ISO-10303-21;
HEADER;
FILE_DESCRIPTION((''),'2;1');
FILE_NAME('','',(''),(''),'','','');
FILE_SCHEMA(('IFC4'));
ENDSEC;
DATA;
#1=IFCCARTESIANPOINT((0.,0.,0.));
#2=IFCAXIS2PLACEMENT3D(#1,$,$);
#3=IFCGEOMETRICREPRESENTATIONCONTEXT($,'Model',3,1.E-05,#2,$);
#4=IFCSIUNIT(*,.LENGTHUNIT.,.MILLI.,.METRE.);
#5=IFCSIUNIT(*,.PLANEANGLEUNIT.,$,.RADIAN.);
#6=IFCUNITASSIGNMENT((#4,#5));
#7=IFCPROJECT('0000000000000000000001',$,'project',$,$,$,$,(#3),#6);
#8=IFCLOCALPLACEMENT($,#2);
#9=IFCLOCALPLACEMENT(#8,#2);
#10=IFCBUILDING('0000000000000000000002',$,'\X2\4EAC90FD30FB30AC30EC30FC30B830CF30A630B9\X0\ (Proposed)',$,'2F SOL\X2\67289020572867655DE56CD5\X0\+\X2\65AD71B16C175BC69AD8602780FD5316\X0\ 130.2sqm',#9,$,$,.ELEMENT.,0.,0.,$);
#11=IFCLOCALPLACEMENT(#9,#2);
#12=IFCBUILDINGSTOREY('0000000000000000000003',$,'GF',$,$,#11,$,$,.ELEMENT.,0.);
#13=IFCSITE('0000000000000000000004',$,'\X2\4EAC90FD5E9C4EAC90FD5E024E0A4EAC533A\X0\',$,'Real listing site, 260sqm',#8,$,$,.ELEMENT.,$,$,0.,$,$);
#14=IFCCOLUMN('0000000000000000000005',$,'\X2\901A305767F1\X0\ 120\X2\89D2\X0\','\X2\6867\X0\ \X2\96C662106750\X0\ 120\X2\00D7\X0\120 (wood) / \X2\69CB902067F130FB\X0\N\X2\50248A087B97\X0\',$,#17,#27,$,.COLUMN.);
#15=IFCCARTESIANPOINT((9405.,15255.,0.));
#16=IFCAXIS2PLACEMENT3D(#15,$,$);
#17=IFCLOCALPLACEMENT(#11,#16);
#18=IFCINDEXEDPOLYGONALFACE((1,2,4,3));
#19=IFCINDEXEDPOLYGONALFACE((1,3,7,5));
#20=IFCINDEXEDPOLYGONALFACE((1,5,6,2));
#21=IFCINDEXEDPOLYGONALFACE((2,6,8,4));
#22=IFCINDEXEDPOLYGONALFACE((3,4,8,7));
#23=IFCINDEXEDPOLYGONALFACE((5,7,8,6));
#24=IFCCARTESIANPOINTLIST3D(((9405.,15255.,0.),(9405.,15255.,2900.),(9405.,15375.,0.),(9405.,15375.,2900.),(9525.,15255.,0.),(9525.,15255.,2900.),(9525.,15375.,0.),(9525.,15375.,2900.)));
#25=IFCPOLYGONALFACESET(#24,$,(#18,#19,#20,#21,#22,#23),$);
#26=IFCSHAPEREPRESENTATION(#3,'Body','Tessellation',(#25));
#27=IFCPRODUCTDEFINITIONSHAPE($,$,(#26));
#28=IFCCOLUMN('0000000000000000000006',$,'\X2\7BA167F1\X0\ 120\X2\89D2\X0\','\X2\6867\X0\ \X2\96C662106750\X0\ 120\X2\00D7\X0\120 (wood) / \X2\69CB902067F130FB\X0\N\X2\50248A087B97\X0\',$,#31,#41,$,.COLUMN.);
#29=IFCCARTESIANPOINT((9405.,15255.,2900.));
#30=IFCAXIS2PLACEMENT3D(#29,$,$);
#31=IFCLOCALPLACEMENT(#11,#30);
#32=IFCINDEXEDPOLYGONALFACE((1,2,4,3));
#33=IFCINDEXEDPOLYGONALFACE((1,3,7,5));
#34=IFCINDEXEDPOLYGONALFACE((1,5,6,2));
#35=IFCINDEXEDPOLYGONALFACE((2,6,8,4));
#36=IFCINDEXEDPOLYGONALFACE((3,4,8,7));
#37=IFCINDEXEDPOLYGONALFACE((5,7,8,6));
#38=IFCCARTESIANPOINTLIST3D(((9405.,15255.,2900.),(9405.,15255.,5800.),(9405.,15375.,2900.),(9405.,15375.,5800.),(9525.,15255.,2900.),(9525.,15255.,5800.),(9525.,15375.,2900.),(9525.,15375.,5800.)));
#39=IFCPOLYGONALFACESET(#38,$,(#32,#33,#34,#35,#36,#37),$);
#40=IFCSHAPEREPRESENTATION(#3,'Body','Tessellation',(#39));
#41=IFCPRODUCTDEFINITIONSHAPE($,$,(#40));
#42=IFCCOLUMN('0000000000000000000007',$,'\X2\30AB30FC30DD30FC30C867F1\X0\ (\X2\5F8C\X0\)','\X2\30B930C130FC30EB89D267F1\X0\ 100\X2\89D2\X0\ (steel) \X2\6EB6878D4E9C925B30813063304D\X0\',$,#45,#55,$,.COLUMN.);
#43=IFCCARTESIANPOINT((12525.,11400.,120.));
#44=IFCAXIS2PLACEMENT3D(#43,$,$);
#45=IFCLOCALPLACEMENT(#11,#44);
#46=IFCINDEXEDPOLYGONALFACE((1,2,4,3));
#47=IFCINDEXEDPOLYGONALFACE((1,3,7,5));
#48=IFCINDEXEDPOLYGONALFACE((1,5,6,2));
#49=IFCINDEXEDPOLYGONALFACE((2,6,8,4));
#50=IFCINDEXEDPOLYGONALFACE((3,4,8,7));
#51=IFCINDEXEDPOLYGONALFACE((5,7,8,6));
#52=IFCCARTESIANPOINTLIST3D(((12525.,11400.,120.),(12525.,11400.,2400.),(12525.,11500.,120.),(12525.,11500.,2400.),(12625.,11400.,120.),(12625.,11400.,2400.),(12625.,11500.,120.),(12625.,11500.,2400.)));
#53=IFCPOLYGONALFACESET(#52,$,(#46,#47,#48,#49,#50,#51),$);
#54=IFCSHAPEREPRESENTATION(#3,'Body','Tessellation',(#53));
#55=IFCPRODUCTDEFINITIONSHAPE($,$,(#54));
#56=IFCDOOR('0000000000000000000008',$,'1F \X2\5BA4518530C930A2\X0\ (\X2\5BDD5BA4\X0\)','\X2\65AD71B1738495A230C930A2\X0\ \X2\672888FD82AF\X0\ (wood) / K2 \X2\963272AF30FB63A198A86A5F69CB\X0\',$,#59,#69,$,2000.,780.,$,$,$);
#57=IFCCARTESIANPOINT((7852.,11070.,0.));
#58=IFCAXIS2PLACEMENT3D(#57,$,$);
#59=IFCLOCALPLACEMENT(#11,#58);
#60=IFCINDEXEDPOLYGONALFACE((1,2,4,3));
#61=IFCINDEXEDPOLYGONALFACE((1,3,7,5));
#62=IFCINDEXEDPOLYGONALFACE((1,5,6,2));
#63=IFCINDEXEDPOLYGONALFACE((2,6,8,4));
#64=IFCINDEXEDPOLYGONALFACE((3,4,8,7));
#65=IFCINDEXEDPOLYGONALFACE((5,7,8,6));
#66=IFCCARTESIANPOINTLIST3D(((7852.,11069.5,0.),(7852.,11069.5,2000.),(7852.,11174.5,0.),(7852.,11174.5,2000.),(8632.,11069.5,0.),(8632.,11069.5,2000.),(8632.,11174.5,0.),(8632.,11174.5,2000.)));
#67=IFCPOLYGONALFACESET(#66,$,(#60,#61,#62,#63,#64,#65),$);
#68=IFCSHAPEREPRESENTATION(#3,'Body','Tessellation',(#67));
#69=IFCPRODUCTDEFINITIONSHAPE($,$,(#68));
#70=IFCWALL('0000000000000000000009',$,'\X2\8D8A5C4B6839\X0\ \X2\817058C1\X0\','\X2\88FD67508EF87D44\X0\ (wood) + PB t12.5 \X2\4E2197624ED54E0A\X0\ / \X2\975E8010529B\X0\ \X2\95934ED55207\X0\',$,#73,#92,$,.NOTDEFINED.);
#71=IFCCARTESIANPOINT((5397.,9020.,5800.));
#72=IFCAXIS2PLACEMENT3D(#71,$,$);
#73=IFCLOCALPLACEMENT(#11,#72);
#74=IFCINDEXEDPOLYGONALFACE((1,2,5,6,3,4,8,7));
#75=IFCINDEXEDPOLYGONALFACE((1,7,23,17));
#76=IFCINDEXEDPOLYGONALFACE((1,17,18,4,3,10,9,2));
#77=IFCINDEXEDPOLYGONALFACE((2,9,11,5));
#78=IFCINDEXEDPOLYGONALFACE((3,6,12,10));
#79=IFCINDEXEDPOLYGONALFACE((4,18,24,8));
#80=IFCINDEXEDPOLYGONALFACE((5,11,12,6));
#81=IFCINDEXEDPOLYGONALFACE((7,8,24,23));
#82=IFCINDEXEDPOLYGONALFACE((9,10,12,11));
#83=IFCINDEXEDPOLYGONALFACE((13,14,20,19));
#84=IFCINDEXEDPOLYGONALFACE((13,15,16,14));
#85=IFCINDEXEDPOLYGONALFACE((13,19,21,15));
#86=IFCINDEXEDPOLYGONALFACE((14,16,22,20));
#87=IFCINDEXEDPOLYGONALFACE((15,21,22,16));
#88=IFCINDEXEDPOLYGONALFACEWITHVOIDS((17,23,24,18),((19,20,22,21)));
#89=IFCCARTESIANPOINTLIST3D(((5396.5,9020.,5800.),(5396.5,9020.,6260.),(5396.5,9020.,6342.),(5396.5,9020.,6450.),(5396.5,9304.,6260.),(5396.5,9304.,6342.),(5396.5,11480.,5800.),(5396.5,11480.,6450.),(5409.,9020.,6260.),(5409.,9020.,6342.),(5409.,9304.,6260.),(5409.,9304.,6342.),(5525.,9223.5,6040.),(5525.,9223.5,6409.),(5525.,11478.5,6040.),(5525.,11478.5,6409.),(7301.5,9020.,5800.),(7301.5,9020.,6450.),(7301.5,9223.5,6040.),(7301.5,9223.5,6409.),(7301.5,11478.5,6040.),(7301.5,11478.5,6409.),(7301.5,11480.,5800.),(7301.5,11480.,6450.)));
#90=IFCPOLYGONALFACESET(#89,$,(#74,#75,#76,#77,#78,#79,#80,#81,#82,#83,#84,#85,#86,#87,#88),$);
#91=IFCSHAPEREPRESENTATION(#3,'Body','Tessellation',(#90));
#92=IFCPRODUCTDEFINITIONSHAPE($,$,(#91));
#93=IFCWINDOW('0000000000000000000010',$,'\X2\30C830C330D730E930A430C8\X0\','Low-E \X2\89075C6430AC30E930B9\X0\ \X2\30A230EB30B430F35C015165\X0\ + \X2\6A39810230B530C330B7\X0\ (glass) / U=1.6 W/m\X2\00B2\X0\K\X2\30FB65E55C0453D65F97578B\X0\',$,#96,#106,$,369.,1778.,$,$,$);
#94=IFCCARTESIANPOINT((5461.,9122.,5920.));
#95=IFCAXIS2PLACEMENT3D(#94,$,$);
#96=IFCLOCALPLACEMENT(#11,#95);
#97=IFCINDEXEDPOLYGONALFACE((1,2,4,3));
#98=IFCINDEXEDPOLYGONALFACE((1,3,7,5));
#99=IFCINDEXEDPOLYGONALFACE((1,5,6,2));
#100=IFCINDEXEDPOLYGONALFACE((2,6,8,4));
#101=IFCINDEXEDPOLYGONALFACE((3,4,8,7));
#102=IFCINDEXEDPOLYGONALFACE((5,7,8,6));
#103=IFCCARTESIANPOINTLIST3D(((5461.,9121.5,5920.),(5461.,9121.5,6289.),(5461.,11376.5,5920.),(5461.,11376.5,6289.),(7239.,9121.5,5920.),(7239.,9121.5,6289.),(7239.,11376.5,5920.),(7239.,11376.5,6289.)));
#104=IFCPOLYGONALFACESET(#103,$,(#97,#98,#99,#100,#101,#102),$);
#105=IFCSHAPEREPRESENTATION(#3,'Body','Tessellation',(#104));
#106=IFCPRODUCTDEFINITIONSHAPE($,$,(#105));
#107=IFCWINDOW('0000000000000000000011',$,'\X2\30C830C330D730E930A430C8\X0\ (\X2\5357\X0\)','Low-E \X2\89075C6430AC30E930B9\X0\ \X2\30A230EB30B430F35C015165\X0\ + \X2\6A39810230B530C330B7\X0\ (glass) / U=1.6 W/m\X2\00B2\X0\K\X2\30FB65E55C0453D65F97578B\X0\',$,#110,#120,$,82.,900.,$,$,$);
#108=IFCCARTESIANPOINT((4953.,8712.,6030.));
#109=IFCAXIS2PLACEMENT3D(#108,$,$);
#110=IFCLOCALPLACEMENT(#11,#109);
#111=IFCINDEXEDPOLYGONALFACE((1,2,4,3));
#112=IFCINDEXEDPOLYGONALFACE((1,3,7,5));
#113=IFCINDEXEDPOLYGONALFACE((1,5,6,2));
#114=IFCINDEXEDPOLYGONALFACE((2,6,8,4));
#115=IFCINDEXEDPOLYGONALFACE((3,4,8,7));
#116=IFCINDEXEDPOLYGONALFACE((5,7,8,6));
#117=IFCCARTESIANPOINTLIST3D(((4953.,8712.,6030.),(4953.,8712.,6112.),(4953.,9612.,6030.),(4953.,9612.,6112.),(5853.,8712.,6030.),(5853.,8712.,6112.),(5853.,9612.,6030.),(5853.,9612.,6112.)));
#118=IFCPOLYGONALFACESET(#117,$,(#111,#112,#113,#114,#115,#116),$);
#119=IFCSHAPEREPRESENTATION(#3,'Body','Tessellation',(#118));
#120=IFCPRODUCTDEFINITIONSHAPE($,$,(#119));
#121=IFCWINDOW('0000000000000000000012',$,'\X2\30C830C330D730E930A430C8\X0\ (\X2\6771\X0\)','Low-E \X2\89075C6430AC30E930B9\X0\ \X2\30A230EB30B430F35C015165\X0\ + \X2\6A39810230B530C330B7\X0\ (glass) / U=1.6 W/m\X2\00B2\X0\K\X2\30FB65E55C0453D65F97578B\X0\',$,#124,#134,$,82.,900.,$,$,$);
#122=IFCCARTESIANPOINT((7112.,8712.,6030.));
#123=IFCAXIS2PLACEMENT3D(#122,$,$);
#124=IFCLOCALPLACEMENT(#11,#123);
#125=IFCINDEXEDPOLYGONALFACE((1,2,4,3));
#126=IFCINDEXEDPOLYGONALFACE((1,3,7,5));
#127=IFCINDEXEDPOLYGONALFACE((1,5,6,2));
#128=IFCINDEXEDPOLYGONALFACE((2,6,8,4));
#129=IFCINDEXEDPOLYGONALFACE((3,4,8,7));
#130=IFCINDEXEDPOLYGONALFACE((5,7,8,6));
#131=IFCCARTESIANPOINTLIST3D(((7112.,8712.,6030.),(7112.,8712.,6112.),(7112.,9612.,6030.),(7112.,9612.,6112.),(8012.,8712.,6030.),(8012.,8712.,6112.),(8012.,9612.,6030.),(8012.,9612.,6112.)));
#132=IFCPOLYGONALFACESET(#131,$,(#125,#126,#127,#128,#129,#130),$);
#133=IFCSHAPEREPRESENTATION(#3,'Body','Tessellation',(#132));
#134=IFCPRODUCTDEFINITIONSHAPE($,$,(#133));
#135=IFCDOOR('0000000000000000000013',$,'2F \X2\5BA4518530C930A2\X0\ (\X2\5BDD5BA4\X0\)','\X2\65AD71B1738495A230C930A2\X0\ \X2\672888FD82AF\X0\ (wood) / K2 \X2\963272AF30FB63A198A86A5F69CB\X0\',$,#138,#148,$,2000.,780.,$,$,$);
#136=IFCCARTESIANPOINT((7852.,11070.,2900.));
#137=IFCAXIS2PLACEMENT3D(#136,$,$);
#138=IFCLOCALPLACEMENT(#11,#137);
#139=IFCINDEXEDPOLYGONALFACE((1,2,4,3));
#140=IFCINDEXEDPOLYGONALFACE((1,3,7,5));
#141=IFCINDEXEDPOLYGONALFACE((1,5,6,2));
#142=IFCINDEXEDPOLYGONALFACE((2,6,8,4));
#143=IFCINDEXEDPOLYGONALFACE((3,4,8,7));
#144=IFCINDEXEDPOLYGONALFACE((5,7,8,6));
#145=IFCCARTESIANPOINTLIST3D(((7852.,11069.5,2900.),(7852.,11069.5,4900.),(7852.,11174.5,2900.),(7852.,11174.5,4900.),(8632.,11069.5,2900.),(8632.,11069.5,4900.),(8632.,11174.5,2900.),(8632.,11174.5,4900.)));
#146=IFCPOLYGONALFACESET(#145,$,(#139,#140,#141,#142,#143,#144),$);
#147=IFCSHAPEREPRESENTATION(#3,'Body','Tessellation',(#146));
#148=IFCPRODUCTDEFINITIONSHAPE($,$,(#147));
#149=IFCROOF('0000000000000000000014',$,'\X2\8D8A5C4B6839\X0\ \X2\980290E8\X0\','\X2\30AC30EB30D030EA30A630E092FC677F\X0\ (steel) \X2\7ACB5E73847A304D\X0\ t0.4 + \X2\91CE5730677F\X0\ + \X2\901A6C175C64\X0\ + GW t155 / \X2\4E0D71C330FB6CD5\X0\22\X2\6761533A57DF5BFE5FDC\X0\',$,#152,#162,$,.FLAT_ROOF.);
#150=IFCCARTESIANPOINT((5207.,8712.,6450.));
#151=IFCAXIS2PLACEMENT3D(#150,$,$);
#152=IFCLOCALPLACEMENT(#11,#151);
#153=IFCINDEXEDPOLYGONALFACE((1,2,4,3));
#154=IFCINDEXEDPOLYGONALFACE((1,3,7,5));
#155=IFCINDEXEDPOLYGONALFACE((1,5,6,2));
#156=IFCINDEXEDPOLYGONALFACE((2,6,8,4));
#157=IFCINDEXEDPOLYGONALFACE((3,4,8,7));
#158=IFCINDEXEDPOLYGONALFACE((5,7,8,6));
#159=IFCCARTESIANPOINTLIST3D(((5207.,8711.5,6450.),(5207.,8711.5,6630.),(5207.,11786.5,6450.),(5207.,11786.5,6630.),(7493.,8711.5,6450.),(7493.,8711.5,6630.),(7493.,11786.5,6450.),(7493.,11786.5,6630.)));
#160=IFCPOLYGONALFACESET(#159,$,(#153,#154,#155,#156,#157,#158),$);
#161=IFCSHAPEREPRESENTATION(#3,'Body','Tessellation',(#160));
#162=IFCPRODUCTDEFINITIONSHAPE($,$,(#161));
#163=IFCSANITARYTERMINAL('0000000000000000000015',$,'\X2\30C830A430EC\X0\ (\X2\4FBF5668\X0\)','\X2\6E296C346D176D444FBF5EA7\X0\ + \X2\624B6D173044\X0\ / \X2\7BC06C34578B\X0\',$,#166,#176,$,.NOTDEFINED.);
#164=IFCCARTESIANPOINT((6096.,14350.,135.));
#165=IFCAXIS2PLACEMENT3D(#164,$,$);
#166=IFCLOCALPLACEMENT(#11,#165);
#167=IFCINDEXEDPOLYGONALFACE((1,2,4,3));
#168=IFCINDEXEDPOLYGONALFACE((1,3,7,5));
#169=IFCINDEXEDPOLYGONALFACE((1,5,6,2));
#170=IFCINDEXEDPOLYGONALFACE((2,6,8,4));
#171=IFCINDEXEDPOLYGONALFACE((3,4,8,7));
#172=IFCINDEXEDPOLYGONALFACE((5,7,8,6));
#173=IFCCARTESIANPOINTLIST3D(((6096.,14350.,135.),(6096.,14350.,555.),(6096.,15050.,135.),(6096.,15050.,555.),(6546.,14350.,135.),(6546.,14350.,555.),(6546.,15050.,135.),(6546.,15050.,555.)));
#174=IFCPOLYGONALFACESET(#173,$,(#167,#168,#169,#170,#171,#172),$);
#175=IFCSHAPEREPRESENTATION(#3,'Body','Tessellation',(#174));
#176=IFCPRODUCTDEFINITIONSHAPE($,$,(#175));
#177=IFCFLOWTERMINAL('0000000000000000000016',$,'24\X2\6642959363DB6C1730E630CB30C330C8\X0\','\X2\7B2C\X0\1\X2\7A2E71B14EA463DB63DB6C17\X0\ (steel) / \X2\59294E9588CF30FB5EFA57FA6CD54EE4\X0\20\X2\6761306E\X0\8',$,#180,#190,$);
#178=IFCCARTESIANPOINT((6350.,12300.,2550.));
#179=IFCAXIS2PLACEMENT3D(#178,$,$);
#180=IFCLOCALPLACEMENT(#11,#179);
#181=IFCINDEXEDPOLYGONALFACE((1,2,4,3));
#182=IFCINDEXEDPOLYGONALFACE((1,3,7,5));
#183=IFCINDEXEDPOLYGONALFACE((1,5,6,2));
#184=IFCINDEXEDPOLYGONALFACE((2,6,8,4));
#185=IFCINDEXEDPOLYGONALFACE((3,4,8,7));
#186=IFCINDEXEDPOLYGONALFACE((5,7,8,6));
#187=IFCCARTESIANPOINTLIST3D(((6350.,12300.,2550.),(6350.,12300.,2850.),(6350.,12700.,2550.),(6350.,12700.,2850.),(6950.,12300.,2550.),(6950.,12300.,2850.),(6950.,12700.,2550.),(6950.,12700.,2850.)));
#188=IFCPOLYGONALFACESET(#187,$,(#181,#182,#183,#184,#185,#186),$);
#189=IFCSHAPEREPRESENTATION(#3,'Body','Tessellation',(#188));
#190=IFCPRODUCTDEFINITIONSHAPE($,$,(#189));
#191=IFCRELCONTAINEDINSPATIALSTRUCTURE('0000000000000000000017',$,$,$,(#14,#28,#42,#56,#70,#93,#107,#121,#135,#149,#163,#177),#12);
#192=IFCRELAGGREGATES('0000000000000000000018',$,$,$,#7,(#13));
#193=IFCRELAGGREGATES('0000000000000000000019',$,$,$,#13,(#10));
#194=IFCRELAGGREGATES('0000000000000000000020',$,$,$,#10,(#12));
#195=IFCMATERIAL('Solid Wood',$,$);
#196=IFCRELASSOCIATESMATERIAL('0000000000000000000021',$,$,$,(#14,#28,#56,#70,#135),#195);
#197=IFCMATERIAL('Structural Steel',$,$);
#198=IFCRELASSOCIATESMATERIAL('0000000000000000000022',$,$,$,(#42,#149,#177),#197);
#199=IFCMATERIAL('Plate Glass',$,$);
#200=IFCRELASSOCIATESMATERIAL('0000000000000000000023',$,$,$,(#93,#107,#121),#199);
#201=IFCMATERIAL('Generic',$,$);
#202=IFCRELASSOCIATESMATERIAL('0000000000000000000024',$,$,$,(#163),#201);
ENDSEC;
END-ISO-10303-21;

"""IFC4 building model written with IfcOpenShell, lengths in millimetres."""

from ifc_helpers import new_model, si_unit, frame, frame_2d, origin, place, context, project, spatial, rectangle, extrude, material, element, fill, save


model = new_model("IFC4")

# Units and contexts
model_context = context("Model", 3, precision=1e-05, world=origin())
ifc_project = project(units=[si_unit("LENGTHUNIT", "METRE", prefix="MILLI"), si_unit("PLANEANGLEUNIT", "RADIAN")], contexts=[model_context])

# Site, building, storey
site_placement = place(None, origin())
site = spatial("IfcSite", under=ifc_project, at=site_placement, Name="京都府京都市上京区", ObjectType="Real listing site, 260sqm", CompositionType="ELEMENT", RefElevation=0.0)
building_placement = place(site_placement, origin())
building = spatial("IfcBuilding", under=site, at=building_placement, Name="京都・ガレージハウス (Proposed)", ObjectType="2F SOL木造在来工法+断熱気密高性能化 130.2sqm", CompositionType="ELEMENT", ElevationOfRefHeight=0.0, ElevationOfTerrain=0.0)
storey_placement = place(building_placement, origin())
storey = spatial("IfcBuildingStorey", under=building, at=storey_placement, Name="GF", CompositionType="ELEMENT", Elevation=0.0)

# Columns
ifc_material_1 = material(Name="Solid Wood")
column_1_placement = place(storey_placement, frame((9405.0, 15255.0, 0.0)))
element("IfcColumn", 1, at=column_1_placement, inside=storey, material=ifc_material_1, Name="通し柱 120角", Description="桧 集成材 120×120 (wood) / 構造柱・N値計算", PredefinedType="COLUMN", context=model_context, shape_type="SweptSolid", body=[
    extrude(rectangle(XDim=120.0, YDim=120.0, at=frame_2d((60.0, 60.0))), frame((9405.0, 15255.0, 0.0)), (0.0, 0.0, 1.0), 2900.0),
])
column_2_placement = place(storey_placement, frame((9405.0, 15255.0, 2900.0)))
element("IfcColumn", 2, at=column_2_placement, inside=storey, material=ifc_material_1, Name="管柱 120角", Description="桧 集成材 120×120 (wood) / 構造柱・N値計算", PredefinedType="COLUMN", context=model_context, shape_type="SweptSolid", body=[
    extrude(rectangle(XDim=120.0, YDim=120.0, at=frame_2d((60.0, 60.0))), frame((9405.0, 15255.0, 2900.0)), (0.0, 0.0, 1.0), 2900.0),
])
ifc_material_2 = material(Name="Structural Steel")
column_3_placement = place(storey_placement, frame((12525.0, 11400.0, 120.0)))
element("IfcColumn", 3, at=column_3_placement, inside=storey, material=ifc_material_2, Name="カーポート柱 (後)", Description="スチール角柱 100角 (steel) 溶融亜鉛めっき", PredefinedType="COLUMN", context=model_context, shape_type="SweptSolid", body=[
    extrude(rectangle(XDim=100.0, YDim=100.0, at=frame_2d((50.0, 50.0))), frame((12525.0, 11400.0, 120.0)), (0.0, 0.0, 1.0), 2280.0),
])

# Door
door_1_placement = place(storey_placement, frame((7852.0, 11070.0, 0.0)))
element("IfcDoor", 4, at=door_1_placement, inside=storey, material=ifc_material_1, Name="1F 室内ドア (寝室)", Description="断熱玄関ドア 木製芯 (wood) / K2 防犯・採風機構", OverallHeight=2000.0, OverallWidth=780.0, context=model_context, shape_type="SweptSolid", body=[
    extrude(rectangle(XDim=780.0, YDim=105.0, at=frame_2d((390.0, 52.0))), frame((7852.0, 11070.0, 0.0)), (0.0, 0.0, 1.0), 2000.0),
])

# Wall, openings, windows
wall_1_placement = place(storey_placement, frame((5397.0, 9020.0, 5800.0)))
wall_1 = element("IfcWall", 5, at=wall_1_placement, inside=storey, material=ifc_material_1, Name="越屋根 腰壁", Description="製材軸組 (wood) + PB t12.5 両面仕上 / 非耐力 間仕切", PredefinedType="NOTDEFINED", context=model_context, shape_type="SweptSolid", body=[
    extrude(rectangle(XDim=1905.0, YDim=2460.0, at=frame_2d((952.0, 1230.0))), frame((5397.0, 9020.0, 5800.0)), (0.0, 0.0, 1.0), 650.0),
])
opening_1_placement = place(storey_placement, frame((5461.0, 9122.0, 5920.0)))
opening_1 = element("IfcOpeningElement", 6, at=opening_1_placement, cuts=wall_1, PredefinedType="NOTDEFINED", context=model_context, shape_type="SweptSolid", body=[
    extrude(rectangle(XDim=1778.0, YDim=2255.0, at=frame_2d((889.0, 1127.0))), frame((5461.0, 9122.0, 5920.0)), (0.0, 0.0, 1.0), 369.0),
])
opening_2_placement = place(storey_placement, frame((4953.0, 8712.0, 6030.0)))
opening_2 = element("IfcOpeningElement", 7, at=opening_2_placement, cuts=wall_1, PredefinedType="NOTDEFINED", context=model_context, shape_type="SweptSolid", body=[
    extrude(rectangle(XDim=900.0, YDim=900.0, at=frame_2d((450.0, 450.0))), frame((4953.0, 8712.0, 6030.0)), (0.0, 0.0, 1.0), 82.0),
])
opening_3_placement = place(storey_placement, frame((7112.0, 8712.0, 6030.0)))
opening_3 = element("IfcOpeningElement", 8, at=opening_3_placement, cuts=wall_1, PredefinedType="NOTDEFINED", context=model_context, shape_type="SweptSolid", body=[
    extrude(rectangle(XDim=900.0, YDim=900.0, at=frame_2d((450.0, 450.0))), frame((7112.0, 8712.0, 6030.0)), (0.0, 0.0, 1.0), 82.0),
])
ifc_material_3 = material(Name="Plate Glass")
window_1_placement = place(storey_placement, frame((5461.0, 9122.0, 5920.0)))
window_1 = element("IfcWindow", 9, at=window_1_placement, inside=storey, material=ifc_material_3, Name="トップライト", Description="Low-E 複層ガラス アルゴン封入 + 樹脂サッシ (glass) / U=1.6 W/m²K・日射取得型", OverallHeight=369.0, OverallWidth=1778.0, context=model_context, shape_type="SweptSolid", body=[
    extrude(rectangle(XDim=1778.0, YDim=2255.0, at=frame_2d((889.0, 1127.0))), frame((5461.0, 9122.0, 5920.0)), (0.0, 0.0, 1.0), 369.0),
])
fill(opening_1, window_1)
window_2_placement = place(storey_placement, frame((4953.0, 8712.0, 6030.0)))
window_2 = element("IfcWindow", 10, at=window_2_placement, inside=storey, material=ifc_material_3, Name="トップライト (南)", Description="Low-E 複層ガラス アルゴン封入 + 樹脂サッシ (glass) / U=1.6 W/m²K・日射取得型", OverallHeight=82.0, OverallWidth=900.0, context=model_context, shape_type="SweptSolid", body=[
    extrude(rectangle(XDim=900.0, YDim=900.0, at=frame_2d((450.0, 450.0))), frame((4953.0, 8712.0, 6030.0)), (0.0, 0.0, 1.0), 82.0),
])
fill(opening_2, window_2)
window_3_placement = place(storey_placement, frame((7112.0, 8712.0, 6030.0)))
window_3 = element("IfcWindow", 11, at=window_3_placement, inside=storey, material=ifc_material_3, Name="トップライト (東)", Description="Low-E 複層ガラス アルゴン封入 + 樹脂サッシ (glass) / U=1.6 W/m²K・日射取得型", OverallHeight=82.0, OverallWidth=900.0, context=model_context, shape_type="SweptSolid", body=[
    extrude(rectangle(XDim=900.0, YDim=900.0, at=frame_2d((450.0, 450.0))), frame((7112.0, 8712.0, 6030.0)), (0.0, 0.0, 1.0), 82.0),
])
fill(opening_3, window_3)

# Door
door_2_placement = place(storey_placement, frame((7852.0, 11070.0, 2900.0)))
element("IfcDoor", 12, at=door_2_placement, inside=storey, material=ifc_material_1, Name="2F 室内ドア (寝室)", Description="断熱玄関ドア 木製芯 (wood) / K2 防犯・採風機構", OverallHeight=2000.0, OverallWidth=780.0, context=model_context, shape_type="SweptSolid", body=[
    extrude(rectangle(XDim=780.0, YDim=105.0, at=frame_2d((390.0, 52.0))), frame((7852.0, 11070.0, 2900.0)), (0.0, 0.0, 1.0), 2000.0),
])

# Roof
roof_placement = place(storey_placement, frame((5207.0, 8712.0, 6450.0)))
element("IfcRoof", 13, at=roof_placement, inside=storey, material=ifc_material_2, Name="越屋根 頂部", Description="ガルバリウム鋼板 (steel) 立平葺き t0.4 + 野地板 + 通気層 + GW t155 / 不燃・法22条区域対応", PredefinedType="FLAT_ROOF", context=model_context, shape_type="SweptSolid", body=[
    extrude(rectangle(XDim=2286.0, YDim=3075.0, at=frame_2d((1143.0, 1537.0))), frame((5207.0, 8712.0, 6450.0)), (0.0, 0.0, 1.0), 180.0),
])

# Sanitary terminal
ifc_material_4 = material(Name="Generic")
sanitary_terminal_placement = place(storey_placement, frame((6096.0, 14350.0, 135.0)))
element("IfcSanitaryTerminal", 14, at=sanitary_terminal_placement, inside=storey, material=ifc_material_4, Name="トイレ (便器)", Description="温水洗浄便座 + 手洗い / 節水型", PredefinedType="NOTDEFINED", context=model_context, shape_type="SweptSolid", body=[
    extrude(rectangle(XDim=450.0, YDim=700.0, at=frame_2d((225.0, 350.0))), frame((6096.0, 14350.0, 135.0)), (0.0, 0.0, 1.0), 420.0),
])

# Flow terminal
flow_terminal_placement = place(storey_placement, frame((6350.0, 12300.0, 2550.0)))
element("IfcFlowTerminal", 15, at=flow_terminal_placement, inside=storey, material=ifc_material_2, Name="24時間換気ユニット", Description="第1種熱交換換気 (steel) / 天井裏・建基法令20条の8", context=model_context, shape_type="SweptSolid", body=[
    extrude(rectangle(XDim=600.0, YDim=400.0, at=frame_2d((300.0, 200.0))), frame((6350.0, 12300.0, 2550.0)), (0.0, 0.0, 1.0), 300.0),
])

save(model, "model.ifc")
